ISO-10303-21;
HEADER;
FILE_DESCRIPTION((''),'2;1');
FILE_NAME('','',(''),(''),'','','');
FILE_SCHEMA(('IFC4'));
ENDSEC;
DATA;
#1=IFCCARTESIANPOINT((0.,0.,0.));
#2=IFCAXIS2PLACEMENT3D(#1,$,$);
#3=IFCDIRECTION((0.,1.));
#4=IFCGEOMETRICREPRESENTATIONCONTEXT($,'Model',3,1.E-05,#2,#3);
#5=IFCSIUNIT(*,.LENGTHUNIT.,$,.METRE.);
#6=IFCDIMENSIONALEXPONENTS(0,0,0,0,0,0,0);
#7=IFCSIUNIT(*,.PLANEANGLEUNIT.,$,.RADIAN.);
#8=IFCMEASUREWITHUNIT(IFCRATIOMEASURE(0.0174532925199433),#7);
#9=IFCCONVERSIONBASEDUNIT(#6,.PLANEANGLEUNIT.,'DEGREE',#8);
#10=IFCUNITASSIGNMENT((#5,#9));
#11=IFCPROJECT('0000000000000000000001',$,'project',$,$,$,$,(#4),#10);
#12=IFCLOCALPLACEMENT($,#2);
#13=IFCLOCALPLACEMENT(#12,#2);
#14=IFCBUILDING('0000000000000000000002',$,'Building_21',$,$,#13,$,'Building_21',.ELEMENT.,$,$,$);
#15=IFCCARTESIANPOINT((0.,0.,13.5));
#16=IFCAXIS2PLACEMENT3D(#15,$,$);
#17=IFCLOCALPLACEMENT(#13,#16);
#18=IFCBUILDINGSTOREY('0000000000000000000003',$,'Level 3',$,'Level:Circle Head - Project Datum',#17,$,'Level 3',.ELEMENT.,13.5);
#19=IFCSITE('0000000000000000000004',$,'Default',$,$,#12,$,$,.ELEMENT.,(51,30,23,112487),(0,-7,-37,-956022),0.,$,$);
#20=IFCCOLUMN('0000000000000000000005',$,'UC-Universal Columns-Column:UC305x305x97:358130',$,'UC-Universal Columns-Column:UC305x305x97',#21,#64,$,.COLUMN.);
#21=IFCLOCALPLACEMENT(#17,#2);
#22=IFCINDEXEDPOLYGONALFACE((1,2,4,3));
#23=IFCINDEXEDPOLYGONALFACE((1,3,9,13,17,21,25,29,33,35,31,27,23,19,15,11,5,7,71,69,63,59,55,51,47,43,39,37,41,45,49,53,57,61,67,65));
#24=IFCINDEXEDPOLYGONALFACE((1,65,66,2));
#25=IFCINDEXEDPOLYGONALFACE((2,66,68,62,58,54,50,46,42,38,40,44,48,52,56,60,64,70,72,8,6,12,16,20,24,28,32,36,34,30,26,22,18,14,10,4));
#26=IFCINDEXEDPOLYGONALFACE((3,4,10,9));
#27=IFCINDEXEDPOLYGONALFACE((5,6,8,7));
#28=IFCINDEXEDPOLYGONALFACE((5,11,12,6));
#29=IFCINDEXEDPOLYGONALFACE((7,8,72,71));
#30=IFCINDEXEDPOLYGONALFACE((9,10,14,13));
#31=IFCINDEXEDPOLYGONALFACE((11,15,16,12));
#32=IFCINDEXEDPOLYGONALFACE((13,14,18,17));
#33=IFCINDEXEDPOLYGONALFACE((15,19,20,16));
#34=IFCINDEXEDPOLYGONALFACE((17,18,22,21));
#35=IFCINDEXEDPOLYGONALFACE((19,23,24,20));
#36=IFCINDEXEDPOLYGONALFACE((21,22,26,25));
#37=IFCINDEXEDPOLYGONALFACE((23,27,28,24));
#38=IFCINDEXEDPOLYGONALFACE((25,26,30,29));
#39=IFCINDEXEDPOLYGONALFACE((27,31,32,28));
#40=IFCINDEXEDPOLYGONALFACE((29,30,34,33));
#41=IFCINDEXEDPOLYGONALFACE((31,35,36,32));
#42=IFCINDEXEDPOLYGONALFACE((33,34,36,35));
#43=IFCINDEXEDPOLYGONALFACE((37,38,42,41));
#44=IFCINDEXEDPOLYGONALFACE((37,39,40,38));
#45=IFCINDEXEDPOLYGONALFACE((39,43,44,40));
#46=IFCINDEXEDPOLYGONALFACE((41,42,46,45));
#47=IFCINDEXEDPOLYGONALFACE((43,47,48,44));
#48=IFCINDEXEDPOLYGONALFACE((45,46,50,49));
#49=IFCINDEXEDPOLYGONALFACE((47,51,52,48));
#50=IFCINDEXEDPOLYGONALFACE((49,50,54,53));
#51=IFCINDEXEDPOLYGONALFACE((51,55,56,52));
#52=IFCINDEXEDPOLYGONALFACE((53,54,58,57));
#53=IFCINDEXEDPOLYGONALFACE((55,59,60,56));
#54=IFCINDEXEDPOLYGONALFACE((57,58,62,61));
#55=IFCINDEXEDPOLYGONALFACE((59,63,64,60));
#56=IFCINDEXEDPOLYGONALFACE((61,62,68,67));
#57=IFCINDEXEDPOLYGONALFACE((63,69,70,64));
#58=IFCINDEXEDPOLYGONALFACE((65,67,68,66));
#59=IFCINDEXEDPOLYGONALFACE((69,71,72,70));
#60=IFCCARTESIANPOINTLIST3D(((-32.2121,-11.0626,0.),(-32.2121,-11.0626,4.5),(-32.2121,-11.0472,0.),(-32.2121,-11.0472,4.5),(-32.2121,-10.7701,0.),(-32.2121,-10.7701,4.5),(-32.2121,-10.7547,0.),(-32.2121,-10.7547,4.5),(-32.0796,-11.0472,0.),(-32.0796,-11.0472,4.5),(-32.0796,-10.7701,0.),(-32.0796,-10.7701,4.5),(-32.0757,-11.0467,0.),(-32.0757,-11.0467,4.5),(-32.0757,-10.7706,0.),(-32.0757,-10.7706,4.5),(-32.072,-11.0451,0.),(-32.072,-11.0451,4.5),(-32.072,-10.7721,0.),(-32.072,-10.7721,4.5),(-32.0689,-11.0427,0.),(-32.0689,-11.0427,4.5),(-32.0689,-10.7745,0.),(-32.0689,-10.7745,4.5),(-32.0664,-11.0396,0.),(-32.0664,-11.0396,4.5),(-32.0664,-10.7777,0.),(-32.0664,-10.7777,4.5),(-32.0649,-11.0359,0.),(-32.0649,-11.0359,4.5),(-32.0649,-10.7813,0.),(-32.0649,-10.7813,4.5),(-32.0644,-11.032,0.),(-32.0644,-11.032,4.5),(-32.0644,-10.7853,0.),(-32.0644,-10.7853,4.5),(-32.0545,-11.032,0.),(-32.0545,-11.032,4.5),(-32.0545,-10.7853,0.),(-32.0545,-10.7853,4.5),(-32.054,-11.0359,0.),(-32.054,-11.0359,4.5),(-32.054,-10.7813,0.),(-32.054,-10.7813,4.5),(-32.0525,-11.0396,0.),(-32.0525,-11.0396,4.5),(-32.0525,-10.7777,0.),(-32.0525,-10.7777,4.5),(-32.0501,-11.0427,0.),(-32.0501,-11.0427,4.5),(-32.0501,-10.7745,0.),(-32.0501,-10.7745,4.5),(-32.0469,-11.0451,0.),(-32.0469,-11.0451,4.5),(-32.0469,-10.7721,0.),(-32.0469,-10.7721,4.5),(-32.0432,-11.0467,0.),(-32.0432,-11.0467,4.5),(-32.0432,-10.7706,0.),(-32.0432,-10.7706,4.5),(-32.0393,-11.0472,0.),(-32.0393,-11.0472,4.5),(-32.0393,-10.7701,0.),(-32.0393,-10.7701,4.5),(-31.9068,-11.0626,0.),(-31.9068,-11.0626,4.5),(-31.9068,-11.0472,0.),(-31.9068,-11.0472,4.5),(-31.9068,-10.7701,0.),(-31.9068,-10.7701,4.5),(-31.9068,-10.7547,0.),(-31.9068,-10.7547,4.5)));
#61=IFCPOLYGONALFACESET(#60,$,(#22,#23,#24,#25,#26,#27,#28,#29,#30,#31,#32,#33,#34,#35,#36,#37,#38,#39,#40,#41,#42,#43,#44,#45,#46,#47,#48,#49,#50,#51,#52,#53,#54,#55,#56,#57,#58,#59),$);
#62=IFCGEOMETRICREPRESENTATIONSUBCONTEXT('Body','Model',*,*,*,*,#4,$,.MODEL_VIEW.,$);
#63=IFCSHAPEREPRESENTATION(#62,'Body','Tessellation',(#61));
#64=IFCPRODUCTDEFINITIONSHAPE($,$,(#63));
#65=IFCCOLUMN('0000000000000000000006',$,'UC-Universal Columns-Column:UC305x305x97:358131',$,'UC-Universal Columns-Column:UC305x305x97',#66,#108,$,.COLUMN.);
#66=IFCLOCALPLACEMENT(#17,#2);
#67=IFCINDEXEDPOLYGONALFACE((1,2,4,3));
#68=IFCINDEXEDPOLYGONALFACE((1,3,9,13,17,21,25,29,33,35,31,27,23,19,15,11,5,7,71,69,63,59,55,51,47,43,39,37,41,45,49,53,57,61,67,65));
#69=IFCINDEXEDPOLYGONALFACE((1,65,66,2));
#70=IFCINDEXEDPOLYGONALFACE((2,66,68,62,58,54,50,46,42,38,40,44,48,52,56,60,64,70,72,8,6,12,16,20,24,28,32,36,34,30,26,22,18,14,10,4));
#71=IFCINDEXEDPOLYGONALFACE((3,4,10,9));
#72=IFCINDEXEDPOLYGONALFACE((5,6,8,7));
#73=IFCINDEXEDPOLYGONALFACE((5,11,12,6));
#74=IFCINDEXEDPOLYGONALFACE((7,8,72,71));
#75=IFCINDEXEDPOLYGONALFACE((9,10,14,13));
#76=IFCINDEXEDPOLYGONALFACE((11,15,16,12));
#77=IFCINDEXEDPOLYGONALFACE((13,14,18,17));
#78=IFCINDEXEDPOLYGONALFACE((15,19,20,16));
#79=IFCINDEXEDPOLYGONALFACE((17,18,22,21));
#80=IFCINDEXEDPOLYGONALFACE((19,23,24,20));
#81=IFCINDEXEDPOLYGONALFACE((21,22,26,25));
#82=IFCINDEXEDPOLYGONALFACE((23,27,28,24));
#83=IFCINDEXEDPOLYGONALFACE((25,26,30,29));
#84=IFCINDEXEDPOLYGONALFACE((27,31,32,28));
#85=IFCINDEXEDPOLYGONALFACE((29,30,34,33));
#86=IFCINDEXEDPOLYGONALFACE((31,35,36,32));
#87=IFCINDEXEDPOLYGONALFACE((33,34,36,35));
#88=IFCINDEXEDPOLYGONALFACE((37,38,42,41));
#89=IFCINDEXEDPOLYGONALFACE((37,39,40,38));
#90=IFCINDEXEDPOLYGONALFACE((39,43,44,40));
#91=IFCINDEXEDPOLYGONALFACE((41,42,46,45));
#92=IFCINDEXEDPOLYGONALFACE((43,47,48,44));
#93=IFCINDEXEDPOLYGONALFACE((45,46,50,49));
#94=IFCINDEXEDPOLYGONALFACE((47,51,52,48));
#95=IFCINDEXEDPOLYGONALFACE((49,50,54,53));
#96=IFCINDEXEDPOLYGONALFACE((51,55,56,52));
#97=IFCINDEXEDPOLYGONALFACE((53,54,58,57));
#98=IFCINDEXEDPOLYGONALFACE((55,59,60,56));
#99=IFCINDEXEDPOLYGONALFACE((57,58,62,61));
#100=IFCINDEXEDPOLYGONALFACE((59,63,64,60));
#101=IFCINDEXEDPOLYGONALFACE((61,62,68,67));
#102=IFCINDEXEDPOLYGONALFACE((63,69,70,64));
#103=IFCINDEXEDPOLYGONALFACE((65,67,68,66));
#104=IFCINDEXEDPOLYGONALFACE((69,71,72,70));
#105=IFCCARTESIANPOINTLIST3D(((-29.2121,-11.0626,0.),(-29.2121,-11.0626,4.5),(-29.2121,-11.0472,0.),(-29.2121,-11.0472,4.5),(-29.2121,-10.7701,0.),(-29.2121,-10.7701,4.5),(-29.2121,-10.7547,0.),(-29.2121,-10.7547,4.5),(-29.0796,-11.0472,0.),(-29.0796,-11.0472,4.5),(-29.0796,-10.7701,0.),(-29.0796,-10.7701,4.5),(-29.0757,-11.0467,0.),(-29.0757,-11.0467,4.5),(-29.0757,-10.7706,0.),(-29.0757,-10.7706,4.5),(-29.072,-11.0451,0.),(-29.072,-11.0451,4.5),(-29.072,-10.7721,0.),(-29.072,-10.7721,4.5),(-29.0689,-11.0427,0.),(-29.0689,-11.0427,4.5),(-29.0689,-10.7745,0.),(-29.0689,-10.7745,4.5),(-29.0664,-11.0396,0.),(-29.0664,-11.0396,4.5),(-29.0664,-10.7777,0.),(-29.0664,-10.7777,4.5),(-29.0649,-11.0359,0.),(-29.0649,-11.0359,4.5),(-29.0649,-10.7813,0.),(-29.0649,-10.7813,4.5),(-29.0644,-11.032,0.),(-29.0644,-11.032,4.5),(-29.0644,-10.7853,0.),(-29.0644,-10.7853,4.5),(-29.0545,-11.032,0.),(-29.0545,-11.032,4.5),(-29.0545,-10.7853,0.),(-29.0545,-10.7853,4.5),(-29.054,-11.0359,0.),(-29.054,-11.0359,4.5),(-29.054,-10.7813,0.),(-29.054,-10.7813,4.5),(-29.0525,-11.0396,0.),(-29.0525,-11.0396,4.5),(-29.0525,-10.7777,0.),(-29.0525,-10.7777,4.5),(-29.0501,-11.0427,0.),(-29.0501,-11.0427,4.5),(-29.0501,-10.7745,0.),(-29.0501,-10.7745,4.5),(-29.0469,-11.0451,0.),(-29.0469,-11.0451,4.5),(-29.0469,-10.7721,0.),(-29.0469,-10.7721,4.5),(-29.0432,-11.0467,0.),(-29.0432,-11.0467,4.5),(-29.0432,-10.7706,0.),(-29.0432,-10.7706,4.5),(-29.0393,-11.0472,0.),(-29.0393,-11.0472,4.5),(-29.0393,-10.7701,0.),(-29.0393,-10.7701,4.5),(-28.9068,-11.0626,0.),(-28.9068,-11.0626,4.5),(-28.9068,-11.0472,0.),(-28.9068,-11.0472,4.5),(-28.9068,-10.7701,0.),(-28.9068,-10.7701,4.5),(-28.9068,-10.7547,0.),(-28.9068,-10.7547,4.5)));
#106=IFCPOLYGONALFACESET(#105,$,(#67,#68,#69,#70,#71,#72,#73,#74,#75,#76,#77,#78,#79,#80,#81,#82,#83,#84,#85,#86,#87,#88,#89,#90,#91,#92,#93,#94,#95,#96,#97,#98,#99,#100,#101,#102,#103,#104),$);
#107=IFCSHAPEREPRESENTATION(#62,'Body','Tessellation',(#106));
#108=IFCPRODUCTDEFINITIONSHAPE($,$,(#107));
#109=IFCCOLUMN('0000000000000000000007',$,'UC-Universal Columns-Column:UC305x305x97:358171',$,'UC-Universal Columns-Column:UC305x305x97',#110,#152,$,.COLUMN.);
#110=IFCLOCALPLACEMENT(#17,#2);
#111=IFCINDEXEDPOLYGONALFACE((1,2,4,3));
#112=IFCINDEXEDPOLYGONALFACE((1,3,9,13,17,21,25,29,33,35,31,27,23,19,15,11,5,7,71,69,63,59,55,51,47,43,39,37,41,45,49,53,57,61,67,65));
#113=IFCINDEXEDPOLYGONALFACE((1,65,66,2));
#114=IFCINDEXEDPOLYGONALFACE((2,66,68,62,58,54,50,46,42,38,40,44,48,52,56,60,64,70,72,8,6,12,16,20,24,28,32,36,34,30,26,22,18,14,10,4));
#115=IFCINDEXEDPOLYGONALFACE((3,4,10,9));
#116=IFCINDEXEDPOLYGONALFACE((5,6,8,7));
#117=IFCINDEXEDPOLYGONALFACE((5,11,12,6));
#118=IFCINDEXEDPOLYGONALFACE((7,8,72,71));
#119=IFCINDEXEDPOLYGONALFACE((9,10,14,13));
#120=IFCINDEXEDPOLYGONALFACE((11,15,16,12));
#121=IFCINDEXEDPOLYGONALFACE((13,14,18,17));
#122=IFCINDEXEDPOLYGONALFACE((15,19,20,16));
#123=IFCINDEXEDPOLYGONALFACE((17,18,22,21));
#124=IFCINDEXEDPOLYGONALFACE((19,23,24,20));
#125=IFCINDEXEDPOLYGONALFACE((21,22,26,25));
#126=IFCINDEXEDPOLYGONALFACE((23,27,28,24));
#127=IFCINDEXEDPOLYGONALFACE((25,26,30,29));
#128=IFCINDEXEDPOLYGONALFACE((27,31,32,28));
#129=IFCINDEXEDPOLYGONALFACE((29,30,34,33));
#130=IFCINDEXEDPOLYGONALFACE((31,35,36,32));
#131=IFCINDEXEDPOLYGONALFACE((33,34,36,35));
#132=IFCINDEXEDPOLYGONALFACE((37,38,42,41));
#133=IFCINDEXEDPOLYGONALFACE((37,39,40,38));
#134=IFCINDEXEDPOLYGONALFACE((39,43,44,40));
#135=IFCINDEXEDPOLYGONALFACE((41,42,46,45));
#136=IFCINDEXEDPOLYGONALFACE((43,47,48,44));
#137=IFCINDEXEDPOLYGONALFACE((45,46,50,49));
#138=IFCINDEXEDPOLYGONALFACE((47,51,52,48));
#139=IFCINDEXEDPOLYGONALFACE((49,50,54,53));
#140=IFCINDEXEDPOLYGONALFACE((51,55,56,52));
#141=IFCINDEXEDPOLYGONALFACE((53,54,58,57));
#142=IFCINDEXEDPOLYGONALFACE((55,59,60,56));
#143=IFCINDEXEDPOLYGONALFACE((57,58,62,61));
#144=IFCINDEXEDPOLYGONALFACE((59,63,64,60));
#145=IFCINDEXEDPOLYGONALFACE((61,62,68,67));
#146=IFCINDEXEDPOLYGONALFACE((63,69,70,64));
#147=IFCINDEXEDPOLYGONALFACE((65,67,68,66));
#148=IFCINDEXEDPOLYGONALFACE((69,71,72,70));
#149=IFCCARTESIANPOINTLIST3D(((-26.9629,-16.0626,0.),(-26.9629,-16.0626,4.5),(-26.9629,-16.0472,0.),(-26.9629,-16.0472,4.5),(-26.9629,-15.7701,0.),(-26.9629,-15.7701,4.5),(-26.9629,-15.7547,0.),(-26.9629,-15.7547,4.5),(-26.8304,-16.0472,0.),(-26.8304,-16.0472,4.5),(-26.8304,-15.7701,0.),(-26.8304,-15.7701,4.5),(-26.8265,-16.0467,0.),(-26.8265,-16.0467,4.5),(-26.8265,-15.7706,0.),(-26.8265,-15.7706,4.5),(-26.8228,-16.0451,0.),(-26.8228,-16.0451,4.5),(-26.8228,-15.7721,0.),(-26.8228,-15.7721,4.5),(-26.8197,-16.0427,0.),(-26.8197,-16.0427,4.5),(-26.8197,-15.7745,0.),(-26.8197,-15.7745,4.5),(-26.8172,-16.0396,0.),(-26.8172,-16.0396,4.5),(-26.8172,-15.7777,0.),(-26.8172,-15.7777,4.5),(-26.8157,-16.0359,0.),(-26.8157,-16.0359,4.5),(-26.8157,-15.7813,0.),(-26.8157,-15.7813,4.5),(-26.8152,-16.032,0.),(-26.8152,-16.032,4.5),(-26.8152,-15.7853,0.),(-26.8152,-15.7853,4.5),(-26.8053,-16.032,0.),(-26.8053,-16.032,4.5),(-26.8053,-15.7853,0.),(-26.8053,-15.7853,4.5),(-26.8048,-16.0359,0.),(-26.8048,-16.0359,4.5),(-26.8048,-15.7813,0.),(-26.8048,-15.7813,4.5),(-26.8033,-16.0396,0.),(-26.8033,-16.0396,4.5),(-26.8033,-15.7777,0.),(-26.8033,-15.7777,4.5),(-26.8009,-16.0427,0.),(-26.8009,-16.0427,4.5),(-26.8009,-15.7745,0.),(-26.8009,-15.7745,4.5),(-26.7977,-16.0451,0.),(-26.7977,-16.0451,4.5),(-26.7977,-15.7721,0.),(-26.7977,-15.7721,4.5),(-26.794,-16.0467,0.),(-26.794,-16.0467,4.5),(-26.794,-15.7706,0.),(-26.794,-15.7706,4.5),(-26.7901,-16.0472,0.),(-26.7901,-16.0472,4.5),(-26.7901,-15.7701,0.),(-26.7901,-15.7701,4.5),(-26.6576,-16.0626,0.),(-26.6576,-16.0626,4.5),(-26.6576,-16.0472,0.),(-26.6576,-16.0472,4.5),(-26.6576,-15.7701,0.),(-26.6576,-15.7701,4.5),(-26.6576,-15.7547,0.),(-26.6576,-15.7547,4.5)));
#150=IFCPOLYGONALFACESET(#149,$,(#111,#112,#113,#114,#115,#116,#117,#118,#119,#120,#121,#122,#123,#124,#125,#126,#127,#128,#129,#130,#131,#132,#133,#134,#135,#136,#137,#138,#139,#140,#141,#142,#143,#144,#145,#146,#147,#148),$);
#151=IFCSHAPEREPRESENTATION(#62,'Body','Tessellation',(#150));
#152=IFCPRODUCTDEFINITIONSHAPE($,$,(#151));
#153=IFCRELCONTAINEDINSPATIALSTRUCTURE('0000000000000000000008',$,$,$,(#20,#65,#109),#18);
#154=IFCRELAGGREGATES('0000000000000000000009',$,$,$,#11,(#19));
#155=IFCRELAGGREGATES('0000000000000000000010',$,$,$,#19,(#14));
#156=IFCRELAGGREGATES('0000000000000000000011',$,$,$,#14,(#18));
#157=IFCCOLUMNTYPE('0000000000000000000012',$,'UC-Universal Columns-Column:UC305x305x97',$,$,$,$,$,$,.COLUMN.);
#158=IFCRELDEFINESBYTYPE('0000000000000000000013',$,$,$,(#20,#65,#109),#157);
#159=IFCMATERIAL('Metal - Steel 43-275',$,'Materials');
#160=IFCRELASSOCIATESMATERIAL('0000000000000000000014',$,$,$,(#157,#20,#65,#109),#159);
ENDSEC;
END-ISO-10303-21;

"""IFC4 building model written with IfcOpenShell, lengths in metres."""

from ifc_helpers import new_model, entity, si_unit, converted_unit, direction, frame, frame_2d, origin, place, context, subcontext, project, spatial, polyline, circle_curve, parameter, trimmed, segment, composite_curve, i_section, outline, extrude, source, transform, mapped, material, material_profile, profile_set, profile_usage, type_object, type_shapes, element, save


model = new_model("IFC4")

# Units and contexts
model_context = context("Model", 3, precision=1e-05, world=origin(), true_north=direction((0.0, 1.0)))
body_context = subcontext(model_context, "Body", "Model", "MODEL_VIEW")
ifc_project = project(units=[si_unit("LENGTHUNIT", "METRE"), converted_unit("PLANEANGLEUNIT", "DEGREE", entity("IfcRatioMeasure", 0.0174532925199433), si_unit("PLANEANGLEUNIT", "RADIAN"), dimensions=[0, 0, 0, 0, 0, 0, 0])], contexts=[model_context])

# Site, building, storey
site_placement = place(None, origin())
site = spatial("IfcSite", under=ifc_project, at=site_placement, Name="Default", CompositionType="ELEMENT", RefLatitude=(51, 30, 23, 112487), RefLongitude=(0, -7, -37, -956022), RefElevation=0.0)
building_placement = place(site_placement, origin())
building = spatial("IfcBuilding", under=site, at=building_placement, Name="Building_21", LongName="Building_21", CompositionType="ELEMENT")
storey_placement = place(building_placement, frame((0.0, 0.0, 13.5)))
storey = spatial("IfcBuildingStorey", under=building, at=storey_placement, Name="Level 3", ObjectType="Level:Circle Head - Project Datum", LongName="Level 3", CompositionType="ELEMENT", Elevation=13.5)

# Columns
ifc_material_1 = material(Name="Metal - Steel 43-275", Category="Materials")
ifc_material_profile_1 = material_profile(ifc_material_1, outline(composite_curve([segment(polyline([(-0.1527, 0.154, 0.0), (0.1527, 0.154, 0.0)]), True, "CONTINUOUS"), segment(polyline([(0.1527, 0.154, 0.0), (0.1527, 0.1386, 0.0)]), True, "CONTINUOUS"), segment(polyline([(0.1527, 0.1386, 0.0), (0.0201, 0.1386, 0.0)]), True, "CONTINUOUS"), segment(trimmed(circle_curve(frame((0.0201, 0.1234, 0.0)), 0.0152), [parameter(90.0)], [parameter(180.0)], True, "PARAMETER"), True, "CONTINUOUS"), segment(polyline([(0.0049, 0.1234, 0.0), (0.0049, -0.1234, 0.0)]), True, "CONTINUOUS"), segment(trimmed(circle_curve(frame((0.0201, -0.1234, 0.0)), 0.0152), [parameter(180.0)], [parameter(270.0)], True, "PARAMETER"), True, "CONTINUOUS"), segment(polyline([(0.0201, -0.1386, 0.0), (0.1527, -0.1386, 0.0)]), True, "CONTINUOUS"), segment(polyline([(0.1527, -0.1386, 0.0), (0.1527, -0.154, 0.0)]), True, "CONTINUOUS"), segment(polyline([(0.1527, -0.154, 0.0), (-0.1527, -0.154, 0.0)]), True, "CONTINUOUS"), segment(polyline([(-0.1527, -0.154, 0.0), (-0.1527, -0.1386, 0.0)]), True, "CONTINUOUS"), segment(polyline([(-0.1527, -0.1386, 0.0), (-0.0201, -0.1386, 0.0)]), True, "CONTINUOUS"), segment(trimmed(circle_curve(frame((-0.0201, -0.1234, 0.0)), 0.0152), [parameter(270.0)], [parameter(0.0)], True, "PARAMETER"), True, "CONTINUOUS"), segment(polyline([(-0.0049, -0.1234, 0.0), (-0.005, 0.1234, 0.0)]), True, "CONTINUOUS"), segment(trimmed(circle_curve(frame((-0.0201, 0.1234, 0.0)), 0.0152), [parameter(0.0)], [parameter(90.0)], True, "PARAMETER"), True, "CONTINUOUS"), segment(polyline([(-0.0201, 0.1386, 0.0), (-0.1527, 0.1386, 0.0)]), True, "CONTINUOUS"), segment(polyline([(-0.1527, 0.1386, 0.0), (-0.1527, 0.154, 0.0)]), True, "CONTINUOUS")], self_intersect=False), kind="CURVE"), Name="UC305x305x97")
ifc_material_profile_2 = material_profile(ifc_material_1, outline(composite_curve([segment(polyline([(0.1527, 0.154, 0.0), (0.1527, 0.1386, 0.0)]), True, "CONTINUOUS"), segment(polyline([(0.1527, 0.1386, 0.0), (0.0049, 0.1386, 0.0)]), True, "CONTINUOUS"), segment(polyline([(0.0049, 0.1386, 0.0), (0.0049, -0.1386, 0.0)]), True, "CONTINUOUS"), segment(polyline([(0.0049, -0.1386, 0.0), (0.1527, -0.1386, 0.0)]), True, "CONTINUOUS"), segment(polyline([(0.1527, -0.1386, 0.0), (0.1527, -0.154, 0.0)]), True, "CONTINUOUS"), segment(polyline([(0.1527, -0.154, 0.0), (-0.1527, -0.154, 0.0)]), True, "CONTINUOUS"), segment(polyline([(-0.1527, -0.154, 0.0), (-0.1527, -0.1386, 0.0)]), True, "CONTINUOUS"), segment(polyline([(-0.1527, -0.1386, 0.0), (-0.005, -0.1386, 0.0)]), True, "CONTINUOUS"), segment(polyline([(-0.005, -0.1386, 0.0), (-0.005, 0.1386, 0.0)]), True, "CONTINUOUS"), segment(polyline([(-0.005, 0.1386, 0.0), (-0.1527, 0.1386, 0.0)]), True, "CONTINUOUS"), segment(polyline([(-0.1527, 0.1386, 0.0), (-0.1527, 0.154, 0.0)]), True, "CONTINUOUS"), segment(polyline([(-0.1527, 0.154, 0.0), (0.1527, 0.154, 0.0)]), True, "CONTINUOUS")], self_intersect=False), kind="CURVE"), Name="UC305x305x97")
ifc_profile_set_1 = profile_set([ifc_material_profile_1, ifc_material_profile_2], Name="UC305x305x97")
ifc_profile_usage_1 = profile_usage(ifc_profile_set_1)
column_type = type_object("IfcColumnType", Name="UC-Universal Columns-Column:UC305x305x97", PredefinedType="COLUMN", material=ifc_profile_set_1)
shared_shape_1 = source(origin(), body_context, "Body", "SweptSolid", [
    extrude(i_section(OverallWidth=0.3053, OverallDepth=0.3079, WebThickness=0.0099, FlangeThickness=0.0154, FilletRadius=0.0152, at=frame_2d((0.0, 0.0), x_axis=(0.0, 1.0))), frame((0.0, 0.0, 13.5), z_axis=(0.0, 0.0, 1.0), x_axis=(0.0, -1.0, 0.0)), (0.0, 0.0, 1.0), 4.5),
])
type_shapes(column_type, [shared_shape_1])
column_1_placement = place(storey_placement, frame((-32.0595, -10.9086, -13.5)))
element("IfcColumn", 1, at=column_1_placement, inside=storey, type_object=column_type, material=ifc_profile_usage_1, Name="UC-Universal Columns-Column:UC305x305x97:358130", ObjectType="UC-Universal Columns-Column:UC305x305x97", PredefinedType="COLUMN", context=body_context, shape_type="MappedRepresentation", body=[
    mapped(shared_shape_1, transform((0.0, 0.0, 0.0), scale=1.0)),
])
ifc_profile_usage_2 = profile_usage(ifc_profile_set_1)
column_2_placement = place(storey_placement, frame((-29.0595, -10.9086, -13.5)))
element("IfcColumn", 2, at=column_2_placement, inside=storey, type_object=column_type, material=ifc_profile_usage_2, Name="UC-Universal Columns-Column:UC305x305x97:358131", ObjectType="UC-Universal Columns-Column:UC305x305x97", PredefinedType="COLUMN", context=body_context, shape_type="MappedRepresentation", body=[
    mapped(shared_shape_1, transform((0.0, 0.0, 0.0), scale=1.0)),
])
ifc_profile_usage_3 = profile_usage(ifc_profile_set_1)
column_3_placement = place(storey_placement, frame((-26.8103, -15.9086, -13.5)))
element("IfcColumn", 3, at=column_3_placement, inside=storey, type_object=column_type, material=ifc_profile_usage_3, Name="UC-Universal Columns-Column:UC305x305x97:358171", ObjectType="UC-Universal Columns-Column:UC305x305x97", PredefinedType="COLUMN", context=body_context, shape_type="MappedRepresentation", body=[
    mapped(shared_shape_1, transform((0.0, 0.0, 0.0), scale=1.0)),
])

save(model, "model.ifc")
